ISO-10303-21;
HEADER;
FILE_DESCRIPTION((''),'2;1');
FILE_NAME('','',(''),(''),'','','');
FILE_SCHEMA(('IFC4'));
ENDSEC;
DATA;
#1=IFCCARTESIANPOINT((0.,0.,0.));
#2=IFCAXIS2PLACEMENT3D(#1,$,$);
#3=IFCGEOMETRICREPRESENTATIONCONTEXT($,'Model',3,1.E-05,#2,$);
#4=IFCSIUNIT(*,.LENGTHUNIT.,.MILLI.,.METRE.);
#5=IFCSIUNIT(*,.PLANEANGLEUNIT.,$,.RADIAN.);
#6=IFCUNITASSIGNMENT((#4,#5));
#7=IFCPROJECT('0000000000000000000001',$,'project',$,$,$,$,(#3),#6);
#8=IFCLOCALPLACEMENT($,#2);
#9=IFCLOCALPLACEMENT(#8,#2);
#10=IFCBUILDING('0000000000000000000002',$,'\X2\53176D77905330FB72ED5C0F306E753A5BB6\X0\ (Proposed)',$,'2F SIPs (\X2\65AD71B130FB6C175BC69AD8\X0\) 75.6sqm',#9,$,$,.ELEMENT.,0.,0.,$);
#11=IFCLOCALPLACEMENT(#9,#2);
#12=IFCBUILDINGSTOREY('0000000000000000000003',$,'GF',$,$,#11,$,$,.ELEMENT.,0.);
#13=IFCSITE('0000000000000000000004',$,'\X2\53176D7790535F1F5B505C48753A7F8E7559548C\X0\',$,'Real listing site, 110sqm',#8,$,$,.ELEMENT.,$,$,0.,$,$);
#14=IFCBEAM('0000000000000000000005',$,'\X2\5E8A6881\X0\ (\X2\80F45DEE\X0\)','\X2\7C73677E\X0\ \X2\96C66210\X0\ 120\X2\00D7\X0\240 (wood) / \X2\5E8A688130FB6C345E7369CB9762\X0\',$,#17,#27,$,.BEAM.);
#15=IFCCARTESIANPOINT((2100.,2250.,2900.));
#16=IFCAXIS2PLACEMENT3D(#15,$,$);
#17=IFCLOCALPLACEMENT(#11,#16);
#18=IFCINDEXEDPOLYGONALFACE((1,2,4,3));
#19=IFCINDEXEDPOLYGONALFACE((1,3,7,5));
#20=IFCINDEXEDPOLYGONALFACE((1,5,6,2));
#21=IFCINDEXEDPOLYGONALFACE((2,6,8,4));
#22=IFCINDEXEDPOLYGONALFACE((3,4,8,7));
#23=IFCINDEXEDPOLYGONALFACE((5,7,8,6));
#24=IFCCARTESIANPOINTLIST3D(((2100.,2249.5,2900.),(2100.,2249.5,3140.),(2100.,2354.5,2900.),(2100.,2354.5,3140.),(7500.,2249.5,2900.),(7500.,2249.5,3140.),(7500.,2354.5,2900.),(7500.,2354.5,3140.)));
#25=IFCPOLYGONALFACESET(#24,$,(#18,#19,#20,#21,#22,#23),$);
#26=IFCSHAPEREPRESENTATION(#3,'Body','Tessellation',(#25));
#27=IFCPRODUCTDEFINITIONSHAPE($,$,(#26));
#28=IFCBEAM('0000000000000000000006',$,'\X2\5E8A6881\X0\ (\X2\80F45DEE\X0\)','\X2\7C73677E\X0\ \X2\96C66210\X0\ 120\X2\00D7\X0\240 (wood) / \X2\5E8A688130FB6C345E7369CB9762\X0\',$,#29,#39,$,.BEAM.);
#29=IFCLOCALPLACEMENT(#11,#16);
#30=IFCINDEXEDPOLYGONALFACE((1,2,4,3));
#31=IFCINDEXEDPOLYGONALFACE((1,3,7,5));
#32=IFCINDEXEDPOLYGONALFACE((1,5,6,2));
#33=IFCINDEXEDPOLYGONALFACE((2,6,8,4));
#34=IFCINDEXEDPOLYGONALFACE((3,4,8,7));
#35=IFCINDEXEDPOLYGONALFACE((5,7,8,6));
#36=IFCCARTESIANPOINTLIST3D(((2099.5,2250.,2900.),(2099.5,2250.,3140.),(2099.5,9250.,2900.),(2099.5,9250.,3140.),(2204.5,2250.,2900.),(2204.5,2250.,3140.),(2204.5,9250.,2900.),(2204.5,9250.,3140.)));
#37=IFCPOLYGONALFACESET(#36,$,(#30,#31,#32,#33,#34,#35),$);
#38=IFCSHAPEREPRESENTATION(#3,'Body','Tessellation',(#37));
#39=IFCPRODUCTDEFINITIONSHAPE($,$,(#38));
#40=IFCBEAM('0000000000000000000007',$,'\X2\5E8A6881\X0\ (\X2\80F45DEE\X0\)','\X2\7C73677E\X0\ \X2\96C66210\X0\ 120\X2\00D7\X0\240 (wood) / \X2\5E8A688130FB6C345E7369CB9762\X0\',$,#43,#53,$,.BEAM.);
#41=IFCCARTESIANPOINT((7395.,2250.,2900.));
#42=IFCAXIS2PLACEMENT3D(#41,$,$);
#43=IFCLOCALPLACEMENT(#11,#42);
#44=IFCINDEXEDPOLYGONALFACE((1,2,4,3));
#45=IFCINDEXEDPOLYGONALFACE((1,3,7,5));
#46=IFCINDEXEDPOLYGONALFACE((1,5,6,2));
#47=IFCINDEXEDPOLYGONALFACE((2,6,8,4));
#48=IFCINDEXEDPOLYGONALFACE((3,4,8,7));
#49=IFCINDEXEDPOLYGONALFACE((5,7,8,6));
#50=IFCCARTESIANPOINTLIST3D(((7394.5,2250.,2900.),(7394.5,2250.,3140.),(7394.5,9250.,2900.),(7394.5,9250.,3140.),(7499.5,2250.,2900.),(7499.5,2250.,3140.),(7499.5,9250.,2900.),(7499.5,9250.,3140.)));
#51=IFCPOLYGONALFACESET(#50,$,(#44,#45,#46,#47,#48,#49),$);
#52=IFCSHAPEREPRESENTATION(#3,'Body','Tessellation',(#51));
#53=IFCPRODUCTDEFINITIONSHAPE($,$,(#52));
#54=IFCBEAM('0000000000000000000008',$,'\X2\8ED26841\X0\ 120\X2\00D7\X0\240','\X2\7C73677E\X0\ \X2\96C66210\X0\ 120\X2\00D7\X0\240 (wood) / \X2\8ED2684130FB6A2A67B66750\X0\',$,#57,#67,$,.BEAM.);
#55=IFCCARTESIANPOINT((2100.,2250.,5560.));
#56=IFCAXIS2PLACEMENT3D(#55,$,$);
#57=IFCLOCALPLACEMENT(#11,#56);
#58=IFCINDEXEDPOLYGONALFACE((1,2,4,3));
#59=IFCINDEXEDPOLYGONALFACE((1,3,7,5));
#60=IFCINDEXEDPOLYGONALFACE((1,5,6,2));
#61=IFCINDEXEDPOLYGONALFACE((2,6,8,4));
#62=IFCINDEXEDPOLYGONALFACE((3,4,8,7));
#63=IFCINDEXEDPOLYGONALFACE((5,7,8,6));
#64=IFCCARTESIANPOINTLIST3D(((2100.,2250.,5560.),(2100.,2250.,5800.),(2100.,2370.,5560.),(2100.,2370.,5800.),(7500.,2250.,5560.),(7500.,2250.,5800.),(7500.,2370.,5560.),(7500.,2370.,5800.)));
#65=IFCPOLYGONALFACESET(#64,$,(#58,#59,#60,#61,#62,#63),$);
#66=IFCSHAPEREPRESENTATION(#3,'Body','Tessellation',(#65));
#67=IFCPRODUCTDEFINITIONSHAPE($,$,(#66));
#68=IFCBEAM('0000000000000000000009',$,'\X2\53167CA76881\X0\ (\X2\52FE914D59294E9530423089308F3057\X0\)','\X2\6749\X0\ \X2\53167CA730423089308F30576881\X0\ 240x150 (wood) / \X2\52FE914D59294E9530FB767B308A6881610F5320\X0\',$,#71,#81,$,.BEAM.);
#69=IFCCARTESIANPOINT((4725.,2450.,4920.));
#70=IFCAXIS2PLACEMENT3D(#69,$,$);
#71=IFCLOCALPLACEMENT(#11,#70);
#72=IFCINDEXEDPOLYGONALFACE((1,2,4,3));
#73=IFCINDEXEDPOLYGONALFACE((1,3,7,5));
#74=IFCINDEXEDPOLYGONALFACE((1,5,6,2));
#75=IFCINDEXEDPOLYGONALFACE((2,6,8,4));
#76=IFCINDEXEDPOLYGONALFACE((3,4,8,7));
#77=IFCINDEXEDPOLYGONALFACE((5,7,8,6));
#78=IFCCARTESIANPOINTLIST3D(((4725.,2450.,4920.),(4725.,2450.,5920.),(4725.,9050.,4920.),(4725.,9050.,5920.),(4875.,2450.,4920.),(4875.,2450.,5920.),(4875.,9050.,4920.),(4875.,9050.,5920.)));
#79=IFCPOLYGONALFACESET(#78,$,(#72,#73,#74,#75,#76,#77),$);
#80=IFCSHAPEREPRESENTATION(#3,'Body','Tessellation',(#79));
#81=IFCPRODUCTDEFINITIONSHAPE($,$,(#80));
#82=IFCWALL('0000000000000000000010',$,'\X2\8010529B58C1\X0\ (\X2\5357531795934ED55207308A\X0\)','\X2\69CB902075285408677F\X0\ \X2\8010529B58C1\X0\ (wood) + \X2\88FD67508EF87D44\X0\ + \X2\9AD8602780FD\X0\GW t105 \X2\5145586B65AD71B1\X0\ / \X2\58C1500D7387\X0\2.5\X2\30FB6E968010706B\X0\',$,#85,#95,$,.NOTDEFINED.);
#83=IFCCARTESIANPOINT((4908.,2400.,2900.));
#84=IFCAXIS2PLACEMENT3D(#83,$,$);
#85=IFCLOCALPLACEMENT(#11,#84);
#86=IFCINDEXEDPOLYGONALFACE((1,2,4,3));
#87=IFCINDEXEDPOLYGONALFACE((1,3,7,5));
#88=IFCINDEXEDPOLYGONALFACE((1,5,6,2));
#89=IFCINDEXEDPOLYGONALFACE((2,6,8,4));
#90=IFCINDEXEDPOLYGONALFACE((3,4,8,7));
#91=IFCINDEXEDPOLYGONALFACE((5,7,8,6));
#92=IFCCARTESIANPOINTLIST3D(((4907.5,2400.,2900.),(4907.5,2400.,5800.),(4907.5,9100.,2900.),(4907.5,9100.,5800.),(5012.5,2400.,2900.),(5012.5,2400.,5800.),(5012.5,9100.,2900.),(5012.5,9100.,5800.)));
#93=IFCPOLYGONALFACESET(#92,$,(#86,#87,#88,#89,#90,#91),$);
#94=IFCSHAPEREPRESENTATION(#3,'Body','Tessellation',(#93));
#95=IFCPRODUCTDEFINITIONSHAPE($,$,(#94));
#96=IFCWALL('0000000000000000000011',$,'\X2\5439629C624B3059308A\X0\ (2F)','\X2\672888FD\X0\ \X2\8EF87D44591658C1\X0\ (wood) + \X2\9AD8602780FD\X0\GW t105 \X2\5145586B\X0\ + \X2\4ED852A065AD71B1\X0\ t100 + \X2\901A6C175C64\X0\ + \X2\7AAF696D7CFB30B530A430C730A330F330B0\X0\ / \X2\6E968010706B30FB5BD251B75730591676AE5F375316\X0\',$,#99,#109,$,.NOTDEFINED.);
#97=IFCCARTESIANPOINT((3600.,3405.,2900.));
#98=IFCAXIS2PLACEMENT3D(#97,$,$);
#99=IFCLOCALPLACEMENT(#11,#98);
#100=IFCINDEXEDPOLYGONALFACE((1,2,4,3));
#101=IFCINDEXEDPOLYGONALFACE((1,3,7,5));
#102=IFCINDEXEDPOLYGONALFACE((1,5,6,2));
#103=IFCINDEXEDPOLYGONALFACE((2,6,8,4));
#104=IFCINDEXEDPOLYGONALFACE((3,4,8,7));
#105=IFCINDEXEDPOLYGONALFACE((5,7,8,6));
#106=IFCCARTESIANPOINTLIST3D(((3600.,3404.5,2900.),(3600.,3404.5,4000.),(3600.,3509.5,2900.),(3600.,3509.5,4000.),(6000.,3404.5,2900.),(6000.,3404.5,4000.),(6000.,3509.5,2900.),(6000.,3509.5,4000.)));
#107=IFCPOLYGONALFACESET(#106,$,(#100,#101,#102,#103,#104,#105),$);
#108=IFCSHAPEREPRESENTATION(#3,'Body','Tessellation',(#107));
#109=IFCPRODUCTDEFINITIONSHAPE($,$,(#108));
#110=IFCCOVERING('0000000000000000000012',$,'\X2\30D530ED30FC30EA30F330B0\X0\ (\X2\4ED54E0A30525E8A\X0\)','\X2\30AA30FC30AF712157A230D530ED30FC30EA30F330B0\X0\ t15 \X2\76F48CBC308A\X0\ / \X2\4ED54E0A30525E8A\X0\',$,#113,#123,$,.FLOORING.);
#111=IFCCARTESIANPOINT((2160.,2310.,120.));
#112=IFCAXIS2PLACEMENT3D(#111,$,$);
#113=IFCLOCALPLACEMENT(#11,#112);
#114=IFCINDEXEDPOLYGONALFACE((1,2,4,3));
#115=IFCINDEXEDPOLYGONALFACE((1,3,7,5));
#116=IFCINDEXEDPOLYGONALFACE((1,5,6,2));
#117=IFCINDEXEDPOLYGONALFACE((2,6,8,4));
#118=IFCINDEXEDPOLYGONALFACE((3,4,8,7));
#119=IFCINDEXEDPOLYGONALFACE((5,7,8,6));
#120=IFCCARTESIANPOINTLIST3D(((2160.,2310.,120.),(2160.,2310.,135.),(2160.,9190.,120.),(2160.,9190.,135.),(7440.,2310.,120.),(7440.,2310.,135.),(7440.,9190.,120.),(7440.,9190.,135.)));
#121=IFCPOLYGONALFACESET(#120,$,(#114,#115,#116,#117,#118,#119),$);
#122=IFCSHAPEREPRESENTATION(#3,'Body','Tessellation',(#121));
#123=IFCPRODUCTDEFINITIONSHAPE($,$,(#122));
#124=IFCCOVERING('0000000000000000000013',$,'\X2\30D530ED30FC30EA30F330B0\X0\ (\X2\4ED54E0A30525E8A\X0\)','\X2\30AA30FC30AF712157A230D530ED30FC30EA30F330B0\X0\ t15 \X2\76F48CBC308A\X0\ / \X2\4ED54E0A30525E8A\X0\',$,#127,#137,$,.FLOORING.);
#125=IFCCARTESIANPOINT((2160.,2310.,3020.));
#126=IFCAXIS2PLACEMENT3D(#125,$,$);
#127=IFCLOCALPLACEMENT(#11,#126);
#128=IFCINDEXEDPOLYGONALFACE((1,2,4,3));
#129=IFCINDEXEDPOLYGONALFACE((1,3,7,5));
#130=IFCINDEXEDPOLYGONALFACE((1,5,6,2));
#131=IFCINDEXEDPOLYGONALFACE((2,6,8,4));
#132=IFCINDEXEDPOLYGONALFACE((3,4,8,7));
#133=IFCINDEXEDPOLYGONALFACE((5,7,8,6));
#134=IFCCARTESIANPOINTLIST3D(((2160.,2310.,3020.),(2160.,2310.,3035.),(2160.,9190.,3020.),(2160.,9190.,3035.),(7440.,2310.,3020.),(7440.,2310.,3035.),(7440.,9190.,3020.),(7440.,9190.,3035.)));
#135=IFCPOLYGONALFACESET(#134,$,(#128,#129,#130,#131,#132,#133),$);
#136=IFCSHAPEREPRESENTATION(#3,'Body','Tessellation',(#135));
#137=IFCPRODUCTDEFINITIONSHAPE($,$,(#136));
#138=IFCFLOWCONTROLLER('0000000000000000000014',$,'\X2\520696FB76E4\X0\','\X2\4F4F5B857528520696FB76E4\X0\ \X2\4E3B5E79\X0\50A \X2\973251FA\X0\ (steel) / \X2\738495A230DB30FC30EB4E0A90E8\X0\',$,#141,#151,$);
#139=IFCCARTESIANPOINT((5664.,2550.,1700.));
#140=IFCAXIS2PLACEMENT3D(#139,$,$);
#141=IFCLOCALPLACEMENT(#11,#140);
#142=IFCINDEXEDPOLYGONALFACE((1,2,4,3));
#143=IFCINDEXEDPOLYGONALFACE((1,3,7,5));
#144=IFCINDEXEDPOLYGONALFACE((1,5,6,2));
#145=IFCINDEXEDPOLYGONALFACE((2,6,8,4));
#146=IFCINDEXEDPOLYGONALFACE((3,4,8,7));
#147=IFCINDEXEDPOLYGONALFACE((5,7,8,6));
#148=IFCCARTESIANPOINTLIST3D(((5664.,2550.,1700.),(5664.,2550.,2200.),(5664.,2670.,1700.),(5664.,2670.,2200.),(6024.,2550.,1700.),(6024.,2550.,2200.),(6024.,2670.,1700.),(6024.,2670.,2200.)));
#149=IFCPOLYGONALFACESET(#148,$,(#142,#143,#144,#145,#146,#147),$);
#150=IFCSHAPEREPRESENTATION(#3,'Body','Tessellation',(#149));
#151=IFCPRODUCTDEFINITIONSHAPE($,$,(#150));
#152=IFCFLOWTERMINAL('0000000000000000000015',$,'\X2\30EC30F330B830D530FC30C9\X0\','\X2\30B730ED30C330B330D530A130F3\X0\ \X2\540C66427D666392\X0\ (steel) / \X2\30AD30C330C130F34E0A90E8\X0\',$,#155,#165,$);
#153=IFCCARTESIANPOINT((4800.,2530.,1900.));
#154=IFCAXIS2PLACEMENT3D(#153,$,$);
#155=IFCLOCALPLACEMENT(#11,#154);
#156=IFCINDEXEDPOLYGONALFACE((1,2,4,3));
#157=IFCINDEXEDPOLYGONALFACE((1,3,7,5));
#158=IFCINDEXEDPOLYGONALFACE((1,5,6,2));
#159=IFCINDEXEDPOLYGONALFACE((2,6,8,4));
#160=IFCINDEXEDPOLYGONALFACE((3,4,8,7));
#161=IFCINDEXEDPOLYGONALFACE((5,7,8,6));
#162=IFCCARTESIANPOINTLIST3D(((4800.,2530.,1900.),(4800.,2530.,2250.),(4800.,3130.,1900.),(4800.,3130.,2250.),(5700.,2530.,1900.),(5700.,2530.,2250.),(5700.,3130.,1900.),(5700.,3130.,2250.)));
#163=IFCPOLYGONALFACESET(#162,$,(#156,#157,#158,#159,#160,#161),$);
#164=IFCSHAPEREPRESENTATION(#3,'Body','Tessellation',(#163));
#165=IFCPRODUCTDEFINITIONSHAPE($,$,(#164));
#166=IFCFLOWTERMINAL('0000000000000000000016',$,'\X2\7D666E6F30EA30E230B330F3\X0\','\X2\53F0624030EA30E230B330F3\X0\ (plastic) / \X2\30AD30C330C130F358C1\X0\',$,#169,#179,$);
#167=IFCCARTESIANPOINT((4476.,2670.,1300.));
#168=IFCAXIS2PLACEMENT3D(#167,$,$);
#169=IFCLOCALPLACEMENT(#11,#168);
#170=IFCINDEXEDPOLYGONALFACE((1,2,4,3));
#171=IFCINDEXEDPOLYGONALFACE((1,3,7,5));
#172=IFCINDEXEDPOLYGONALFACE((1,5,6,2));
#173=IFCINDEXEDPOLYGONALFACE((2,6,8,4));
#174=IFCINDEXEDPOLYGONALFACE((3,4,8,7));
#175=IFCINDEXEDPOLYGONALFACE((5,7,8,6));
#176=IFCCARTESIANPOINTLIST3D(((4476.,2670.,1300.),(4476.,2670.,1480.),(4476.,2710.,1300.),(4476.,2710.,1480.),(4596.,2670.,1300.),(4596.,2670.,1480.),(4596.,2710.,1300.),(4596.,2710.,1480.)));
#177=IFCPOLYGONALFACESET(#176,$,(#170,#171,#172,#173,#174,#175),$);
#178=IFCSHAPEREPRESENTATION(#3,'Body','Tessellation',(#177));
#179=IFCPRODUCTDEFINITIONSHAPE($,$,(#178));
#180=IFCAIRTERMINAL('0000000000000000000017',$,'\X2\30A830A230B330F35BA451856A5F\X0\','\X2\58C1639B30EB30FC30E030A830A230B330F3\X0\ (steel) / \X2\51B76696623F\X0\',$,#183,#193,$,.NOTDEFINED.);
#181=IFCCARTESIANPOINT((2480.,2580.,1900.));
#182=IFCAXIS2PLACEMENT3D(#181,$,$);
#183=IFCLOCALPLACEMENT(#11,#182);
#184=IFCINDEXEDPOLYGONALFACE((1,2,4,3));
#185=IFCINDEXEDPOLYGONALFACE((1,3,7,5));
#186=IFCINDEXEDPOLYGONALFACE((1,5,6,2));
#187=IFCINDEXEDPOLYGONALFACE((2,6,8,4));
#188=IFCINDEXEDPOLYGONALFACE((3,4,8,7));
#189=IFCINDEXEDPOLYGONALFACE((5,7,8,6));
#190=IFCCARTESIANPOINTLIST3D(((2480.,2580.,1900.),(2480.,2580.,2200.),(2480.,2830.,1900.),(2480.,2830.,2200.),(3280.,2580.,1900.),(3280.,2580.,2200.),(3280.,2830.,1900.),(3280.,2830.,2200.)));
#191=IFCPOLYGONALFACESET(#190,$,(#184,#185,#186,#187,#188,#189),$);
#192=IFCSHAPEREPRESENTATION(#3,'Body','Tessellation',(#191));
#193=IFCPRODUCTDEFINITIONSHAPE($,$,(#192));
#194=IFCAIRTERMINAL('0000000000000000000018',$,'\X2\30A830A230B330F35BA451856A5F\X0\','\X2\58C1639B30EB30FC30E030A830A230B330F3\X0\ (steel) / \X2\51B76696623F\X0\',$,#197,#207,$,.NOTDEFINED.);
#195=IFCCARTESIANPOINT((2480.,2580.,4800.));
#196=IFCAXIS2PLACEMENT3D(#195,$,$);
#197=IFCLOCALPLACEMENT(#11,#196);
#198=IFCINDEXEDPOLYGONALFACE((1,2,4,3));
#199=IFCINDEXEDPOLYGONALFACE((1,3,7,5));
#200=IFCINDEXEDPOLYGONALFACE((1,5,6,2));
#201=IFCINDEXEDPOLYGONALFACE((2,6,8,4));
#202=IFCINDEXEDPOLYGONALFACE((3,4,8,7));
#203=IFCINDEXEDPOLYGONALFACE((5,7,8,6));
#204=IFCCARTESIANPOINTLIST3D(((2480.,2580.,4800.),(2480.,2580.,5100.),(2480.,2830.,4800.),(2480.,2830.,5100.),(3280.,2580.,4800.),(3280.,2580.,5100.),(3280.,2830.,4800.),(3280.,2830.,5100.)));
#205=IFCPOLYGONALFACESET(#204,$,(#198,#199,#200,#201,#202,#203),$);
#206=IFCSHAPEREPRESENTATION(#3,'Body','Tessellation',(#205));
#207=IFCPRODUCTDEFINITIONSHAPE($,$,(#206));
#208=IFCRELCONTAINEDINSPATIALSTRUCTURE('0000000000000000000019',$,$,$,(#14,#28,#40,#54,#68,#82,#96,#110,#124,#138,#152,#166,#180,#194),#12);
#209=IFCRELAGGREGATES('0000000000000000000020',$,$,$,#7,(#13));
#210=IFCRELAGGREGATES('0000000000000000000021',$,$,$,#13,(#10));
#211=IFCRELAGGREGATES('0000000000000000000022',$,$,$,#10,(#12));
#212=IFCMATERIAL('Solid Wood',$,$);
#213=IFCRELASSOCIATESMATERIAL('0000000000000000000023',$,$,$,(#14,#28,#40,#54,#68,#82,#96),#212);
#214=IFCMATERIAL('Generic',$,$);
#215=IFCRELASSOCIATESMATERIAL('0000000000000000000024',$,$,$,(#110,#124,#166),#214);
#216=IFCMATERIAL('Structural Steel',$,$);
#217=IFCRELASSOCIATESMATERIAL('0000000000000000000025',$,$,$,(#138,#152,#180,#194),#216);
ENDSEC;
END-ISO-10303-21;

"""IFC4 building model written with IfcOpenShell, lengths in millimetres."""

from ifc_helpers import new_model, si_unit, frame, frame_2d, origin, place, context, project, spatial, rectangle, extrude, material, element, save


model = new_model("IFC4")

# Units and contexts
model_context = context("Model", 3, precision=1e-05, world=origin())
ifc_project = project(units=[si_unit("LENGTHUNIT", "METRE", prefix="MILLI"), si_unit("PLANEANGLEUNIT", "RADIAN")], contexts=[model_context])

# Site, building, storey
site_placement = place(None, origin())
site = spatial("IfcSite", under=ifc_project, at=site_placement, Name="北海道弟子屈町美留和", ObjectType="Real listing site, 110sqm", CompositionType="ELEMENT", RefElevation=0.0)
building_placement = place(site_placement, origin())
building = spatial("IfcBuilding", under=site, at=building_placement, Name="北海道・狭小の町家 (Proposed)", ObjectType="2F SIPs (断熱・気密高) 75.6sqm", CompositionType="ELEMENT", ElevationOfRefHeight=0.0, ElevationOfTerrain=0.0)
storey_placement = place(building_placement, origin())
storey = spatial("IfcBuildingStorey", under=building, at=storey_placement, Name="GF", CompositionType="ELEMENT", Elevation=0.0)

# Beams
ifc_material_1 = material(Name="Solid Wood")
beam_1_placement = place(storey_placement, frame((2100.0, 2250.0, 2900.0)))
element("IfcBeam", 1, at=beam_1_placement, inside=storey, material=ifc_material_1, Name="床梁 (胴差)", Description="米松 集成 120×240 (wood) / 床梁・水平構面", PredefinedType="BEAM", context=model_context, shape_type="SweptSolid", body=[
    extrude(rectangle(XDim=5400.0, YDim=105.0, at=frame_2d((2700.0, 52.0))), frame((2100.0, 2250.0, 2900.0)), (0.0, 0.0, 1.0), 240.0),
])
beam_2_placement = place(storey_placement, frame((2100.0, 2250.0, 2900.0)))
element("IfcBeam", 2, at=beam_2_placement, inside=storey, material=ifc_material_1, Name="床梁 (胴差)", Description="米松 集成 120×240 (wood) / 床梁・水平構面", PredefinedType="BEAM", context=model_context, shape_type="SweptSolid", body=[
    extrude(rectangle(XDim=105.0, YDim=7000.0, at=frame_2d((52.0, 3500.0))), frame((2100.0, 2250.0, 2900.0)), (0.0, 0.0, 1.0), 240.0),
])
beam_3_placement = place(storey_placement, frame((7395.0, 2250.0, 2900.0)))
element("IfcBeam", 3, at=beam_3_placement, inside=storey, material=ifc_material_1, Name="床梁 (胴差)", Description="米松 集成 120×240 (wood) / 床梁・水平構面", PredefinedType="BEAM", context=model_context, shape_type="SweptSolid", body=[
    extrude(rectangle(XDim=105.0, YDim=7000.0, at=frame_2d((52.0, 3500.0))), frame((7395.0, 2250.0, 2900.0)), (0.0, 0.0, 1.0), 240.0),
])
beam_4_placement = place(storey_placement, frame((2100.0, 2250.0, 5560.0)))
element("IfcBeam", 4, at=beam_4_placement, inside=storey, material=ifc_material_1, Name="軒桁 120×240", Description="米松 集成 120×240 (wood) / 軒桁・横架材", PredefinedType="BEAM", context=model_context, shape_type="SweptSolid", body=[
    extrude(rectangle(XDim=5400.0, YDim=120.0, at=frame_2d((2700.0, 60.0))), frame((2100.0, 2250.0, 5560.0)), (0.0, 0.0, 1.0), 240.0),
])
beam_5_placement = place(storey_placement, frame((4725.0, 2450.0, 4920.0)))
element("IfcBeam", 5, at=beam_5_placement, inside=storey, material=ifc_material_1, Name="化粧梁 (勾配天井あらわし)", Description="杉 化粧あらわし梁 240x150 (wood) / 勾配天井・登り梁意匠", PredefinedType="BEAM", context=model_context, shape_type="SweptSolid", body=[
    extrude(rectangle(XDim=150.0, YDim=6600.0, at=frame_2d((75.0, 3300.0))), frame((4725.0, 2450.0, 4920.0)), (0.0, 0.0, 1.0), 1000.0),
])

# Walls
wall_1_placement = place(storey_placement, frame((4908.0, 2400.0, 2900.0)))
element("IfcWall", 6, at=wall_1_placement, inside=storey, material=ifc_material_1, Name="耐力壁 (南北間仕切り)", Description="構造用合板 耐力壁 (wood) + 製材軸組 + 高性能GW t105 充填断熱 / 壁倍率2.5・準耐火", PredefinedType="NOTDEFINED", context=model_context, shape_type="SweptSolid", body=[
    extrude(rectangle(XDim=105.0, YDim=6700.0, at=frame_2d((52.0, 3350.0))), frame((4908.0, 2400.0, 2900.0)), (0.0, 0.0, 1.0), 2900.0),
])
wall_2_placement = place(storey_placement, frame((3600.0, 3405.0, 2900.0)))
element("IfcWall", 7, at=wall_2_placement, inside=storey, material=ifc_material_1, Name="吹抜手すり (2F)", Description="木製 軸組外壁 (wood) + 高性能GW t105 充填 + 付加断熱 t100 + 通気層 + 窯業系サイディング / 準耐火・寒冷地外皮強化", PredefinedType="NOTDEFINED", context=model_context, shape_type="SweptSolid", body=[
    extrude(rectangle(XDim=2400.0, YDim=105.0, at=frame_2d((1200.0, 52.0))), frame((3600.0, 3405.0, 2900.0)), (0.0, 0.0, 1.0), 1100.0),
])

# Coverings
ifc_material_2 = material(Name="Generic")
covering_1_placement = place(storey_placement, frame((2160.0, 2310.0, 120.0)))
element("IfcCovering", 8, at=covering_1_placement, inside=storey, material=ifc_material_2, Name="フローリング (仕上げ床)", Description="オーク無垢フローリング t15 直貼り / 仕上げ床", PredefinedType="FLOORING", context=model_context, shape_type="SweptSolid", body=[
    extrude(rectangle(XDim=5280.0, YDim=6880.0, at=frame_2d((2640.0, 3440.0))), frame((2160.0, 2310.0, 120.0)), (0.0, 0.0, 1.0), 15.0),
])
covering_2_placement = place(storey_placement, frame((2160.0, 2310.0, 3020.0)))
element("IfcCovering", 9, at=covering_2_placement, inside=storey, material=ifc_material_2, Name="フローリング (仕上げ床)", Description="オーク無垢フローリング t15 直貼り / 仕上げ床", PredefinedType="FLOORING", context=model_context, shape_type="SweptSolid", body=[
    extrude(rectangle(XDim=5280.0, YDim=6880.0, at=frame_2d((2640.0, 3440.0))), frame((2160.0, 2310.0, 3020.0)), (0.0, 0.0, 1.0), 15.0),
])

# Flow controller
ifc_material_3 = material(Name="Structural Steel")
flow_controller_placement = place(storey_placement, frame((5664.0, 2550.0, 1700.0)))
element("IfcFlowController", 10, at=flow_controller_placement, inside=storey, material=ifc_material_3, Name="分電盤", Description="住宅用分電盤 主幹50A 露出 (steel) / 玄関ホール上部", context=model_context, shape_type="SweptSolid", body=[
    extrude(rectangle(XDim=360.0, YDim=120.0, at=frame_2d((180.0, 60.0))), frame((5664.0, 2550.0, 1700.0)), (0.0, 0.0, 1.0), 500.0),
])

# Flow terminals
flow_terminal_1_placement = place(storey_placement, frame((4800.0, 2530.0, 1900.0)))
element("IfcFlowTerminal", 11, at=flow_terminal_1_placement, inside=storey, material=ifc_material_3, Name="レンジフード", Description="シロッコファン 同時給排 (steel) / キッチン上部", context=model_context, shape_type="SweptSolid", body=[
    extrude(rectangle(XDim=900.0, YDim=600.0, at=frame_2d((450.0, 300.0))), frame((4800.0, 2530.0, 1900.0)), (0.0, 0.0, 1.0), 350.0),
])
flow_terminal_2_placement = place(storey_placement, frame((4476.0, 2670.0, 1300.0)))
element("IfcFlowTerminal", 12, at=flow_terminal_2_placement, inside=storey, material=ifc_material_2, Name="給湯リモコン", Description="台所リモコン (plastic) / キッチン壁", context=model_context, shape_type="SweptSolid", body=[
    extrude(rectangle(XDim=120.0, YDim=40.0, at=frame_2d((60.0, 20.0))), frame((4476.0, 2670.0, 1300.0)), (0.0, 0.0, 1.0), 180.0),
])

# Air terminals
air_terminal_1_placement = place(storey_placement, frame((2480.0, 2580.0, 1900.0)))
element("IfcAirTerminal", 13, at=air_terminal_1_placement, inside=storey, material=ifc_material_3, Name="エアコン室内機", Description="壁掛ルームエアコン (steel) / 冷暖房", PredefinedType="NOTDEFINED", context=model_context, shape_type="SweptSolid", body=[
    extrude(rectangle(XDim=800.0, YDim=250.0, at=frame_2d((400.0, 125.0))), frame((2480.0, 2580.0, 1900.0)), (0.0, 0.0, 1.0), 300.0),
])
air_terminal_2_placement = place(storey_placement, frame((2480.0, 2580.0, 4800.0)))
element("IfcAirTerminal", 14, at=air_terminal_2_placement, inside=storey, material=ifc_material_3, Name="エアコン室内機", Description="壁掛ルームエアコン (steel) / 冷暖房", PredefinedType="NOTDEFINED", context=model_context, shape_type="SweptSolid", body=[
    extrude(rectangle(XDim=800.0, YDim=250.0, at=frame_2d((400.0, 125.0))), frame((2480.0, 2580.0, 4800.0)), (0.0, 0.0, 1.0), 300.0),
])

save(model, "model.ifc")
